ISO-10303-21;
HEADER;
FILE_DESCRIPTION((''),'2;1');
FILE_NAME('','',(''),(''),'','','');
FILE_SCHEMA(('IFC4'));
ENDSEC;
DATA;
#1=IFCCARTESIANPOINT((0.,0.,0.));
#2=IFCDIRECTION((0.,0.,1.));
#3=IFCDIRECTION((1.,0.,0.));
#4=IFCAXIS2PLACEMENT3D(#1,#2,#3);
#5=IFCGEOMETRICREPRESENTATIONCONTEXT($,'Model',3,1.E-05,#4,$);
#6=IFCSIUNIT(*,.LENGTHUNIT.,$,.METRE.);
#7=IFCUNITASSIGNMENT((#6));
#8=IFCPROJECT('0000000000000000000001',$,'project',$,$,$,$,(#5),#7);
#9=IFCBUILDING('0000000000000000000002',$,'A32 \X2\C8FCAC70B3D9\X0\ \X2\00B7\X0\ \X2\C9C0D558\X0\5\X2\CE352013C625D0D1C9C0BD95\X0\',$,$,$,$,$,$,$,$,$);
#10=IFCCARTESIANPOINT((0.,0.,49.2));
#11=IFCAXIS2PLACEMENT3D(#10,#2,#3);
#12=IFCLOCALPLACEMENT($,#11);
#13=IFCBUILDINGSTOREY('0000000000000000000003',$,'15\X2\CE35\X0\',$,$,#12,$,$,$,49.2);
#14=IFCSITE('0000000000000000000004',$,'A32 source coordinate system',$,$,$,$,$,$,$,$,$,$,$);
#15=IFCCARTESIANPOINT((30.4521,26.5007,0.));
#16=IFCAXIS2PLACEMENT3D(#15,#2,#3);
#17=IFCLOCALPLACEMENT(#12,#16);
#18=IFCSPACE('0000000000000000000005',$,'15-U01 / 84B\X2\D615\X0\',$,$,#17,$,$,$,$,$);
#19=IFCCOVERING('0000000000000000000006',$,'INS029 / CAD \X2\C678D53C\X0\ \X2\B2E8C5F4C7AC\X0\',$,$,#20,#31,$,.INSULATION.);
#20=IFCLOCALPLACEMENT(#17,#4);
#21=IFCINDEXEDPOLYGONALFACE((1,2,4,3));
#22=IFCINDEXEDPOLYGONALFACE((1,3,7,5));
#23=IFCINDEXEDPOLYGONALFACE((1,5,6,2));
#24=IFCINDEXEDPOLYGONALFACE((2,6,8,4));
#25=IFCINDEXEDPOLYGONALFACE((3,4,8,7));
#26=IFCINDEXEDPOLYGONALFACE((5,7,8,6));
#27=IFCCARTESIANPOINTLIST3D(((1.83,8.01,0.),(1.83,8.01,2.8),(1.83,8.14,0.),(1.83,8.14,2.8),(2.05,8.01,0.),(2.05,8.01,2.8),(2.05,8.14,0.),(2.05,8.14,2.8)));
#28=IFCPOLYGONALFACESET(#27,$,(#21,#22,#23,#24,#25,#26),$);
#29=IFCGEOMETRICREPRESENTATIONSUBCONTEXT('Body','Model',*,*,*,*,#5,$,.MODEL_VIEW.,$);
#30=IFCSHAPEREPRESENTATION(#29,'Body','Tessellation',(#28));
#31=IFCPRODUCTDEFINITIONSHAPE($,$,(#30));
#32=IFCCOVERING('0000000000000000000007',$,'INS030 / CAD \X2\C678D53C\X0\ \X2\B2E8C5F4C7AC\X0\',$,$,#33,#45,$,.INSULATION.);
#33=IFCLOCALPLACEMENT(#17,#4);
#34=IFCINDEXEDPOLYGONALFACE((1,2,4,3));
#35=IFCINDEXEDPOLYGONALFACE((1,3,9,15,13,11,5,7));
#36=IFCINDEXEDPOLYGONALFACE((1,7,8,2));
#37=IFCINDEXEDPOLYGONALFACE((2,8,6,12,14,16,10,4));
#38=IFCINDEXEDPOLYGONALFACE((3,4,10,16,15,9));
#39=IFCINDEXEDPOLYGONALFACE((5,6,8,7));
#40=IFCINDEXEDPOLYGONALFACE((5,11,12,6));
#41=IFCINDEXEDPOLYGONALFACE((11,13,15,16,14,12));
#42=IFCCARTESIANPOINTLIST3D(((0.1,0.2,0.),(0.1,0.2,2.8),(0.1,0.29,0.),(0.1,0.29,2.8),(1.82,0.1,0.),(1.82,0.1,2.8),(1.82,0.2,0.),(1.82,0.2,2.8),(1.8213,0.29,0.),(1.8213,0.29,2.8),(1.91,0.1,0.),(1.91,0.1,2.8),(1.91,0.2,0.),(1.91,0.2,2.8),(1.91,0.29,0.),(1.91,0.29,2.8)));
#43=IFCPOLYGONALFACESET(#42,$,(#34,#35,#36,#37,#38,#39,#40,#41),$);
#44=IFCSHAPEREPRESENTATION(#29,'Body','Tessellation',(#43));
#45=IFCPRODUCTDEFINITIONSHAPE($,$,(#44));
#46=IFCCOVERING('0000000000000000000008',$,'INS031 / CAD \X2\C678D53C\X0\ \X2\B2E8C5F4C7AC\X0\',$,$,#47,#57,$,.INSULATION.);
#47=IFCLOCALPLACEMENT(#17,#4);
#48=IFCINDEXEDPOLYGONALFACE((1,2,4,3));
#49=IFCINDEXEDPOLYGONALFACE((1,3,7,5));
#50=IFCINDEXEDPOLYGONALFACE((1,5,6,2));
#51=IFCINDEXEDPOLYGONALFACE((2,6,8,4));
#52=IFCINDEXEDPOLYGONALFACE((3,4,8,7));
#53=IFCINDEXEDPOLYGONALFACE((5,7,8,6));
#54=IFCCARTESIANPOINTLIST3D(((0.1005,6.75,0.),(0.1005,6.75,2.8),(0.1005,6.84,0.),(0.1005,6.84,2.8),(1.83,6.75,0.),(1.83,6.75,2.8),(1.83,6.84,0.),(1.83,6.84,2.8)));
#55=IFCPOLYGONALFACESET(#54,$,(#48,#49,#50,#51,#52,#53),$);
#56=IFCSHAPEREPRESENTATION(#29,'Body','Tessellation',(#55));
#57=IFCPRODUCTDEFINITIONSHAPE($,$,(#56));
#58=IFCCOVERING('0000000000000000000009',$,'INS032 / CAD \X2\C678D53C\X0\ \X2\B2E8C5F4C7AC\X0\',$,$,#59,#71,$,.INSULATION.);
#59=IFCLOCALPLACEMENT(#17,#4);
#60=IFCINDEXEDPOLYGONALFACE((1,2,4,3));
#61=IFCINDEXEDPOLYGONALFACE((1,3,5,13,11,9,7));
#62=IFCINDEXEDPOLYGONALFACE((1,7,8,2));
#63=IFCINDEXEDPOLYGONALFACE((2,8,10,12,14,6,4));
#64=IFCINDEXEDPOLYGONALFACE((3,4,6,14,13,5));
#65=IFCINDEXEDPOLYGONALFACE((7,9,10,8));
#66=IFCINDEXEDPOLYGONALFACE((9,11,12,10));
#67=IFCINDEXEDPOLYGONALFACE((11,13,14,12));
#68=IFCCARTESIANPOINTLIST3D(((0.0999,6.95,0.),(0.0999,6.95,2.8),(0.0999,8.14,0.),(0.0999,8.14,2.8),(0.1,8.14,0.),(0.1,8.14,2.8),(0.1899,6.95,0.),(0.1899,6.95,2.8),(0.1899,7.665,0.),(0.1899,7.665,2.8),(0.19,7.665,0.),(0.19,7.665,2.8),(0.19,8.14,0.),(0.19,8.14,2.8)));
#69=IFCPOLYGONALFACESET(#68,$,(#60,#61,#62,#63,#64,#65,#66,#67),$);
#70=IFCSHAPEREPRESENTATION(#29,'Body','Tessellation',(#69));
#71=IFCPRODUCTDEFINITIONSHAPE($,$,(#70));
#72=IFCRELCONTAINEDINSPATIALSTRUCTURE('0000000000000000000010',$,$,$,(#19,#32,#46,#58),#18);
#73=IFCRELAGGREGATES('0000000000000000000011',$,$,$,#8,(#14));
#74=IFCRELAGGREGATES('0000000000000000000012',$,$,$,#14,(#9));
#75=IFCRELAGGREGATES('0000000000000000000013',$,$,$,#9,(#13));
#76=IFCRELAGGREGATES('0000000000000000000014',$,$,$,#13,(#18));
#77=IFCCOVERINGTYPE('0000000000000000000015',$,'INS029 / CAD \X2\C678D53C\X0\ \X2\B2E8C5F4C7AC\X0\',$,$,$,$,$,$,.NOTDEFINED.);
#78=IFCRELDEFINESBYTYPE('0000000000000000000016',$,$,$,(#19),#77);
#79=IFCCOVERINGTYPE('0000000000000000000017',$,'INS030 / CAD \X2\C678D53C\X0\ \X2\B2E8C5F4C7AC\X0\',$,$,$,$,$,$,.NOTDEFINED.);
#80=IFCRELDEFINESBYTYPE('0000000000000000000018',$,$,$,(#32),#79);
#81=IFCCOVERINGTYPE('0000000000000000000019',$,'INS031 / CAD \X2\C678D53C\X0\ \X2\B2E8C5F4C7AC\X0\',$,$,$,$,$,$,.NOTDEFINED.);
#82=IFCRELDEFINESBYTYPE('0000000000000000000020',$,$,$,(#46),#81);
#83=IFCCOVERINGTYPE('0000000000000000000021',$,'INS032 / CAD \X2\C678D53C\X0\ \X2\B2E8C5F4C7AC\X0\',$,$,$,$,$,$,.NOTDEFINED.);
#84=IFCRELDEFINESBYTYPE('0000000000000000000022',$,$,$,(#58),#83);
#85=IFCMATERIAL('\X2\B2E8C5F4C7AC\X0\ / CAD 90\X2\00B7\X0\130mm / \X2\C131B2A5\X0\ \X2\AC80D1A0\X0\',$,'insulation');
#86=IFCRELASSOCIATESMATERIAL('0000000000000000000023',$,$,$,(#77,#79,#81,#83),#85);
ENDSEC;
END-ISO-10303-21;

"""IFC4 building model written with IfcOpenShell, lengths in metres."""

from ifc_helpers import new_model, si_unit, frame, origin, origin_with_axes, place, context, subcontext, project, spatial, polyline, outline, extrude, source, transform, mapped, material, type_object, type_shapes, element, save


model = new_model("IFC4")

# Units and contexts
model_context = context("Model", 3, precision=1e-05, world=origin_with_axes())
body_context = subcontext(model_context, "Body", "Model", "MODEL_VIEW")
ifc_project = project(units=[si_unit("LENGTHUNIT", "METRE")], contexts=[model_context])

# Site, building, storey, space
storey_placement = place(None, frame((0.0, 0.0, 49.2), z_axis=(0.0, 0.0, 1.0), x_axis=(1.0, 0.0, 0.0)))
space_placement = place(storey_placement, frame((30.4521, 26.5007, 0.0), z_axis=(0.0, 0.0, 1.0), x_axis=(1.0, 0.0, 0.0)))
site = spatial("IfcSite", under=ifc_project, Name="A32 source coordinate system")
building = spatial("IfcBuilding", under=site, Name="A32 주거동 · 지하5층–옥탑지붕")
storey = spatial("IfcBuildingStorey", under=building, at=storey_placement, Name="15층", Elevation=49.2)
space = spatial("IfcSpace", under=storey, at=space_placement, Name="15-U01 / 84B형")

# Coverings
ifc_material = material(Name="단열재 / CAD 90·130mm / 성능 검토", Category="insulation")
covering_type_1 = type_object("IfcCoveringType", Name="INS029 / CAD 외피 단열재", PredefinedType="NOTDEFINED", material=ifc_material)
shared_shape_1 = source(origin(), body_context, "Body", "SweptSolid", [
    extrude(outline(polyline([(1.83, 8.01), (1.83, 8.14), (2.05, 8.14), (2.05, 8.01), (1.83, 8.01)])), origin(), (0.0, 0.0, 1.0), 2.8),
])
type_shapes(covering_type_1, [shared_shape_1])
covering_1_placement = place(space_placement, origin_with_axes())
element("IfcCovering", 1, at=covering_1_placement, inside=space, type_object=covering_type_1, Name="INS029 / CAD 외피 단열재", PredefinedType="INSULATION", context=body_context, shape_type="MappedRepresentation", body=[
    mapped(shared_shape_1, transform((0.0, 0.0, 0.0), scale=1.0)),
])
covering_type_2 = type_object("IfcCoveringType", Name="INS030 / CAD 외피 단열재", PredefinedType="NOTDEFINED", material=ifc_material)
shared_shape_2 = source(origin(), body_context, "Body", "SweptSolid", [
    extrude(outline(polyline([(1.91, 0.2), (1.91, 0.1), (1.82, 0.1), (1.82, 0.2), (0.1, 0.2), (0.1, 0.29), (1.8213, 0.29), (1.91, 0.29), (1.91, 0.2)])), origin(), (0.0, 0.0, 1.0), 2.8),
])
type_shapes(covering_type_2, [shared_shape_2])
covering_2_placement = place(space_placement, origin_with_axes())
element("IfcCovering", 2, at=covering_2_placement, inside=space, type_object=covering_type_2, Name="INS030 / CAD 외피 단열재", PredefinedType="INSULATION", context=body_context, shape_type="MappedRepresentation", body=[
    mapped(shared_shape_2, transform((0.0, 0.0, 0.0), scale=1.0)),
])
covering_type_3 = type_object("IfcCoveringType", Name="INS031 / CAD 외피 단열재", PredefinedType="NOTDEFINED", material=ifc_material)
shared_shape_3 = source(origin(), body_context, "Body", "SweptSolid", [
    extrude(outline(polyline([(1.83, 6.75), (0.1005, 6.75), (0.1005, 6.84), (1.83, 6.84), (1.83, 6.75)])), origin(), (0.0, 0.0, 1.0), 2.8),
])
type_shapes(covering_type_3, [shared_shape_3])
covering_3_placement = place(space_placement, origin_with_axes())
element("IfcCovering", 3, at=covering_3_placement, inside=space, type_object=covering_type_3, Name="INS031 / CAD 외피 단열재", PredefinedType="INSULATION", context=body_context, shape_type="MappedRepresentation", body=[
    mapped(shared_shape_3, transform((0.0, 0.0, 0.0), scale=1.0)),
])
covering_type_4 = type_object("IfcCoveringType", Name="INS032 / CAD 외피 단열재", PredefinedType="NOTDEFINED", material=ifc_material)
shared_shape_4 = source(origin(), body_context, "Body", "SweptSolid", [
    extrude(outline(polyline([(0.1899, 6.95), (0.0999, 6.95), (0.0999, 8.14), (0.1, 8.14), (0.19, 8.14), (0.19, 7.665), (0.1899, 7.665), (0.1899, 6.95)])), origin(), (0.0, 0.0, 1.0), 2.8),
])
type_shapes(covering_type_4, [shared_shape_4])
covering_4_placement = place(space_placement, origin_with_axes())
element("IfcCovering", 4, at=covering_4_placement, inside=space, type_object=covering_type_4, Name="INS032 / CAD 외피 단열재", PredefinedType="INSULATION", context=body_context, shape_type="MappedRepresentation", body=[
    mapped(shared_shape_4, transform((0.0, 0.0, 0.0), scale=1.0)),
])

save(model, "model.ifc")
